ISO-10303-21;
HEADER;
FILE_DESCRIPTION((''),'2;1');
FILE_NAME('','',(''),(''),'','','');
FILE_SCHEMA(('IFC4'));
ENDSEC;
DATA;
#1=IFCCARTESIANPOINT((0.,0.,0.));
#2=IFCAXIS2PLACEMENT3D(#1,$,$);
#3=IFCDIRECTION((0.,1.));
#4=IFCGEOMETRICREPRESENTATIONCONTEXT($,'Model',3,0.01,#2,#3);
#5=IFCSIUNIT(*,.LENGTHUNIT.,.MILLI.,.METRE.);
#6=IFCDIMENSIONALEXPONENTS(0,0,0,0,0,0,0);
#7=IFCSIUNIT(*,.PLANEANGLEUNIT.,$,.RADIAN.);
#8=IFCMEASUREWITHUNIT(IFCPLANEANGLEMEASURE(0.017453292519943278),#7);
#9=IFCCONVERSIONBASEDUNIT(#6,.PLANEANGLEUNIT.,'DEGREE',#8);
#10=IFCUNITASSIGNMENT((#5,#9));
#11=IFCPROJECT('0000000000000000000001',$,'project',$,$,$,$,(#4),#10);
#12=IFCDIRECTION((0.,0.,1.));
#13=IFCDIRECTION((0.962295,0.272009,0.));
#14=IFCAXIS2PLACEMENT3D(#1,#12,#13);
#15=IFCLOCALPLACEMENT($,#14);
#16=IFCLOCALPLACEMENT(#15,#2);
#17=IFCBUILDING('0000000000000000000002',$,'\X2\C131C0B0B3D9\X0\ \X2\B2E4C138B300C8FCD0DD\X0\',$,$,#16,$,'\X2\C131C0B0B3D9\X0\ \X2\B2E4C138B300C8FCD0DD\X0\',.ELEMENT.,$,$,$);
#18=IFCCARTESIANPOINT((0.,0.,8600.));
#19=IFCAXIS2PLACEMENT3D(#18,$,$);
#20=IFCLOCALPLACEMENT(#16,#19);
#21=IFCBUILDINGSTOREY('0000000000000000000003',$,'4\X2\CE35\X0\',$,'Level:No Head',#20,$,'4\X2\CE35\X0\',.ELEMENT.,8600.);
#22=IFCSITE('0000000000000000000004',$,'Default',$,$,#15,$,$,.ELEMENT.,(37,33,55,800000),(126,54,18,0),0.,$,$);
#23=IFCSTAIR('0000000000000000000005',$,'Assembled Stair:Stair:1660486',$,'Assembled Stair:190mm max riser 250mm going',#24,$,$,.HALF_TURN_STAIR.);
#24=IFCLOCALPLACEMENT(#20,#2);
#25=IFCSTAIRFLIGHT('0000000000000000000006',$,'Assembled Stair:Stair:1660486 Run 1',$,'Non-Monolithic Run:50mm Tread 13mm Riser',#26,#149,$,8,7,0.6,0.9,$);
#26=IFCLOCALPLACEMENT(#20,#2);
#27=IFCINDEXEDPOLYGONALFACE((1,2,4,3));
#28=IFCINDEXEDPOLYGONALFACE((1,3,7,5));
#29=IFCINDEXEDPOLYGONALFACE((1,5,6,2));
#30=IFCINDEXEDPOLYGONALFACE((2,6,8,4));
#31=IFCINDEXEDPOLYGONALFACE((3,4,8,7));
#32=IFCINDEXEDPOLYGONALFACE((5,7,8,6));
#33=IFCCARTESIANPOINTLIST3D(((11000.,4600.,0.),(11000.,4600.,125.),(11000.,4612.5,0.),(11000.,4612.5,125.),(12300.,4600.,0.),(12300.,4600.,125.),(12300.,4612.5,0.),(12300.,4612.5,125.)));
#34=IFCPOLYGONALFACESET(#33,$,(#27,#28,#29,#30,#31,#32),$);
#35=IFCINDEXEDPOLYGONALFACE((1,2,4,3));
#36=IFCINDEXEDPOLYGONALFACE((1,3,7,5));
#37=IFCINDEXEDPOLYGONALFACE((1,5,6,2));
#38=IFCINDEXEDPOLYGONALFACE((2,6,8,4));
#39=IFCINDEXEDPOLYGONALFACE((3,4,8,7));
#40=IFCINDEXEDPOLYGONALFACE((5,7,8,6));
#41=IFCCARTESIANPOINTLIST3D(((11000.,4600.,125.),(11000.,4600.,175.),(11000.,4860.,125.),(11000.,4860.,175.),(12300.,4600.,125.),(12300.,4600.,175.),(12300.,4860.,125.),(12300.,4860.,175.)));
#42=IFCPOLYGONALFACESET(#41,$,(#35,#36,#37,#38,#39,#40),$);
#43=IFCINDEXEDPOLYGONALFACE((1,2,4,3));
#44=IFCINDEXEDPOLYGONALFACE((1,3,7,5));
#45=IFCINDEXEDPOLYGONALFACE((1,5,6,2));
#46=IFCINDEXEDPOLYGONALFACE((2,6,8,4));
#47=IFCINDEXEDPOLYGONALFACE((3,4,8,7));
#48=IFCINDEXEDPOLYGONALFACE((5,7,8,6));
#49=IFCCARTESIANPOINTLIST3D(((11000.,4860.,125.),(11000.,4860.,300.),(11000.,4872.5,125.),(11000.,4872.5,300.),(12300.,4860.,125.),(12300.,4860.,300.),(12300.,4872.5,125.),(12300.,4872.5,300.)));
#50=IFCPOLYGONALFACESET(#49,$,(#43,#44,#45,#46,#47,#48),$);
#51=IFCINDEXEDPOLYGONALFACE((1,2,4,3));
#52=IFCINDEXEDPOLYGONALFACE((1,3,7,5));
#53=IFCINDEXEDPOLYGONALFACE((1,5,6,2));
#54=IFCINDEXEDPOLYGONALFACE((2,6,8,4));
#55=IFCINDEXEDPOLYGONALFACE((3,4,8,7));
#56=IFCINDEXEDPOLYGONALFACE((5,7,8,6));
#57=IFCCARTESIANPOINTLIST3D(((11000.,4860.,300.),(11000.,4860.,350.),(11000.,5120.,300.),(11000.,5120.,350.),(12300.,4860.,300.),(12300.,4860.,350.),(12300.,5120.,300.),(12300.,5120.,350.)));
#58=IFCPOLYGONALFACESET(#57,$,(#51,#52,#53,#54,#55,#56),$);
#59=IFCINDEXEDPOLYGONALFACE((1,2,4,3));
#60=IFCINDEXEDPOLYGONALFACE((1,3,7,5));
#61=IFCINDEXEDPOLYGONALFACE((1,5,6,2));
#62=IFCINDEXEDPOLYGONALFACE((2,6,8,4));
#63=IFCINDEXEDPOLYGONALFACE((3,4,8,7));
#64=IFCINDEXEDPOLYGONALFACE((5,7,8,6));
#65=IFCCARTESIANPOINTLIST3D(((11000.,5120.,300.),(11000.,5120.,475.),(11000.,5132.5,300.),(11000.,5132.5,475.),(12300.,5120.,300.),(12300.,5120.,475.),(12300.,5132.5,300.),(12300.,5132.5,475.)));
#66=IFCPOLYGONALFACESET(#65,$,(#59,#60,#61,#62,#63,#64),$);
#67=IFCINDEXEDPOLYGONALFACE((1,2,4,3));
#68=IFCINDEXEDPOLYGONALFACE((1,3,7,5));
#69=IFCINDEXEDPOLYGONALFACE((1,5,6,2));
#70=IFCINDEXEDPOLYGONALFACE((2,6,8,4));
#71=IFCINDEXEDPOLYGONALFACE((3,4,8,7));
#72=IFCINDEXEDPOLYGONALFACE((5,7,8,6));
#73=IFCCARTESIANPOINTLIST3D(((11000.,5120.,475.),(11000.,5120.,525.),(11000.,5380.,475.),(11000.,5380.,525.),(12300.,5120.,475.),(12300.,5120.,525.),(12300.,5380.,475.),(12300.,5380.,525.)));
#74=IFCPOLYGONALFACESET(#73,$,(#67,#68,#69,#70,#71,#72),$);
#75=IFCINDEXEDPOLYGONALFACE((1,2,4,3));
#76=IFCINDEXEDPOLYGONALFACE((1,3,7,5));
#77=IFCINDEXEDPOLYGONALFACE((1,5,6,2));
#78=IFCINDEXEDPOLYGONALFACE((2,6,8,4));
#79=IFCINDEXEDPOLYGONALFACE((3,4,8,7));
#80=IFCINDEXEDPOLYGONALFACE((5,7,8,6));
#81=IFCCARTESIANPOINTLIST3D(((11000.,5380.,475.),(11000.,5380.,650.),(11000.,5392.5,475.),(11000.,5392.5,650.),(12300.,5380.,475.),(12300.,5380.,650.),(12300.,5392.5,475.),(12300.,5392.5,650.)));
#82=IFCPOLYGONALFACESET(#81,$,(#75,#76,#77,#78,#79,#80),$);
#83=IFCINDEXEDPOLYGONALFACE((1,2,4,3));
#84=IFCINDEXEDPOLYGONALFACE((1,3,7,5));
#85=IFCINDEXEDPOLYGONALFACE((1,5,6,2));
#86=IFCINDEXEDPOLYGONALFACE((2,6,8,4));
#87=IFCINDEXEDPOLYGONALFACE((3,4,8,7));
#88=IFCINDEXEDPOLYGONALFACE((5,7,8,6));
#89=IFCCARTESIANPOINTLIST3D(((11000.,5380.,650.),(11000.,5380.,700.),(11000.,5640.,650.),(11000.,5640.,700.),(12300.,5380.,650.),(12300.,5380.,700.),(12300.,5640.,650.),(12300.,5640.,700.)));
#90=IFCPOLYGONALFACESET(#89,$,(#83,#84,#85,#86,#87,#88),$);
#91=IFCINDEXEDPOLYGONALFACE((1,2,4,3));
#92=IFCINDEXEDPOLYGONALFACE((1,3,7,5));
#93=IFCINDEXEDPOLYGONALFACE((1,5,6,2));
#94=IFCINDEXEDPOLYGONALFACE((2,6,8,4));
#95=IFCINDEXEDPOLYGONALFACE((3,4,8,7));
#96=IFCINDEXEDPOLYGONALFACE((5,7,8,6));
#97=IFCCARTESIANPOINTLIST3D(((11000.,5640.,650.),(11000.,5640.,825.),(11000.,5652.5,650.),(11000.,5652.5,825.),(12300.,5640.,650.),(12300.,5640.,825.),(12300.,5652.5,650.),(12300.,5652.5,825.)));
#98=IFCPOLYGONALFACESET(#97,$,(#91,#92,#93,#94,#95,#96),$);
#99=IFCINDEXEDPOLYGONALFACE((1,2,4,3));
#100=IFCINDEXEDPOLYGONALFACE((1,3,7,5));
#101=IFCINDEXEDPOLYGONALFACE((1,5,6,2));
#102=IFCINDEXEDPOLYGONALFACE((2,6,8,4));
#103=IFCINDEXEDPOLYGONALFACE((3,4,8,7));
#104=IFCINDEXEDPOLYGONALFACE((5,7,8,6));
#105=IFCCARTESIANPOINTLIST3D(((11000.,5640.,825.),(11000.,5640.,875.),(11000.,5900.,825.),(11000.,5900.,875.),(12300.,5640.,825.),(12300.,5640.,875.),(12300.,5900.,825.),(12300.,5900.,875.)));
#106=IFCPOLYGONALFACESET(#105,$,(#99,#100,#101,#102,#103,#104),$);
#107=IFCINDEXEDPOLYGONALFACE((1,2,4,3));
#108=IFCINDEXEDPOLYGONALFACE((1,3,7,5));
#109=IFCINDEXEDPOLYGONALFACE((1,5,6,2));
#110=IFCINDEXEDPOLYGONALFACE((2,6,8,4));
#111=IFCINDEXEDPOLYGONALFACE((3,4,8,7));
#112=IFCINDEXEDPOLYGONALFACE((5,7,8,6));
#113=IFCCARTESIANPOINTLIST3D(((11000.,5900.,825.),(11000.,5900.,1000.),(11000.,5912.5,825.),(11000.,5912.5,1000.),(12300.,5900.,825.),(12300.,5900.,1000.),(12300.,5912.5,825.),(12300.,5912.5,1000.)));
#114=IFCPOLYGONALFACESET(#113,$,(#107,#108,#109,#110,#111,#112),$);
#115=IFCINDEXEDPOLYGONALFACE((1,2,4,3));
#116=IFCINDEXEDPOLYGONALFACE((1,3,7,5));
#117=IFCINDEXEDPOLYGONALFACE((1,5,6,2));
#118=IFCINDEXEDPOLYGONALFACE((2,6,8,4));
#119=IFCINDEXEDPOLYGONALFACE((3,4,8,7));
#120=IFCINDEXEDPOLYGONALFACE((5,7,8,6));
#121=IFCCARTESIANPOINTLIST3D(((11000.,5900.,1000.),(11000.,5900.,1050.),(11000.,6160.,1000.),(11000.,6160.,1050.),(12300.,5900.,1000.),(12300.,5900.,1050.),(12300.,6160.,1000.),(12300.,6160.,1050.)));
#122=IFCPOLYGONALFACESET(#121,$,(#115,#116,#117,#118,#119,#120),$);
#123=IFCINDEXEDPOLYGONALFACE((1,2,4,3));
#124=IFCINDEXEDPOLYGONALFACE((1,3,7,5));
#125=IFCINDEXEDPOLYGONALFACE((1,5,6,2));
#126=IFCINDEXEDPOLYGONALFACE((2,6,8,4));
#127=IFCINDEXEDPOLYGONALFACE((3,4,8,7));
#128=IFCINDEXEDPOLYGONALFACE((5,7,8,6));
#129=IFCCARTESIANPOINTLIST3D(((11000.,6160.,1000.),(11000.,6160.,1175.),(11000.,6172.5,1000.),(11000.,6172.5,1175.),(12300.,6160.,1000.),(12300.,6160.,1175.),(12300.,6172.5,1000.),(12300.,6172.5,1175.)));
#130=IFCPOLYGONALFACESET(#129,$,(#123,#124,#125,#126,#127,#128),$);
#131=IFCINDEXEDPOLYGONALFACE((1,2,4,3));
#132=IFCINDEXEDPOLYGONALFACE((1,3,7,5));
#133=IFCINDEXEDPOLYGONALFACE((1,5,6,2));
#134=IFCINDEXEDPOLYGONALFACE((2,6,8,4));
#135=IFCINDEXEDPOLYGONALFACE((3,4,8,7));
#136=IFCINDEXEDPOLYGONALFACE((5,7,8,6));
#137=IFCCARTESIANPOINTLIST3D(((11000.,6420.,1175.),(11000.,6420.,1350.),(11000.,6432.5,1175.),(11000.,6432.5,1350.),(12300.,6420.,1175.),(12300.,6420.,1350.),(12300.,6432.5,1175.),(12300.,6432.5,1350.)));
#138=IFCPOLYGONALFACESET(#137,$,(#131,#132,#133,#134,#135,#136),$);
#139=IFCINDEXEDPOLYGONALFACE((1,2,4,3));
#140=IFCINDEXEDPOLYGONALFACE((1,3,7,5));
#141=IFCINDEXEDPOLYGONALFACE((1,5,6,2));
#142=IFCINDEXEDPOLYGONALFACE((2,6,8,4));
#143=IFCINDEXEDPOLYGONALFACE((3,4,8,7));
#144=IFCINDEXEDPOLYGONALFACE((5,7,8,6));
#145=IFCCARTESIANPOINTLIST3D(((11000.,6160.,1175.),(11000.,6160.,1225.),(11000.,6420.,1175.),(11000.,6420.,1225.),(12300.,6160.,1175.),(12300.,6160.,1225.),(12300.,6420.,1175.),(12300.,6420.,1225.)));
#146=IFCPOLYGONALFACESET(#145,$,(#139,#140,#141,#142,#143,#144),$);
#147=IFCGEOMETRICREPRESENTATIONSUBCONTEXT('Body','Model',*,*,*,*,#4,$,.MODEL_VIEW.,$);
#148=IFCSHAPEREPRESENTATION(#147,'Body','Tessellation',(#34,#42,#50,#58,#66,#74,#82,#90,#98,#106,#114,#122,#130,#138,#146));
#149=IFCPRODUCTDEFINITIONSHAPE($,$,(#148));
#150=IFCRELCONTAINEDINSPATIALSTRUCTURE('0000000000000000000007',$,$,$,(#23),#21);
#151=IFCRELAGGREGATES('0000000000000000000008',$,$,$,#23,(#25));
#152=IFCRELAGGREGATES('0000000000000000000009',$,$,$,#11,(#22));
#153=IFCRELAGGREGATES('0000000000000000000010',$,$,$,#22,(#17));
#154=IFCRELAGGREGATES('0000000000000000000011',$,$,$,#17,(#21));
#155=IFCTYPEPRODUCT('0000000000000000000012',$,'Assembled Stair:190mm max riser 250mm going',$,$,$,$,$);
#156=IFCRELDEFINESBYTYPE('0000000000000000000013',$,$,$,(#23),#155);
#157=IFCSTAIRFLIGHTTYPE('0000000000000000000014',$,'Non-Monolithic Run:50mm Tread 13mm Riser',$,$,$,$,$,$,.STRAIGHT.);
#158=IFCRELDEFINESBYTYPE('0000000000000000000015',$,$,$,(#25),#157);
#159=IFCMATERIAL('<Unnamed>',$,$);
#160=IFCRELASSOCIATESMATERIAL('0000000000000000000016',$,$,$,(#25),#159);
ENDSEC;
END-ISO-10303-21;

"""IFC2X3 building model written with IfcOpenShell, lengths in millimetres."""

from ifc_helpers import new_model, entity, si_unit, converted_unit, direction, frame, frame_2d, origin, origin_2d_with_axis, place, context, subcontext, project, spatial, rectangle, extrude, material, type_object, element, aggregate, save


model = new_model("IFC2X3")

# Units and contexts
model_context = context("Model", 3, precision=0.01, world=origin(), true_north=direction((0.0, 1.0)))
body_context = subcontext(model_context, "Body", "Model", "MODEL_VIEW")
ifc_project = project(units=[si_unit("LENGTHUNIT", "METRE", prefix="MILLI"), converted_unit("PLANEANGLEUNIT", "DEGREE", entity("IfcPlaneAngleMeasure", 0.017453292519943278), si_unit("PLANEANGLEUNIT", "RADIAN"), dimensions=[0, 0, 0, 0, 0, 0, 0])], contexts=[model_context])

# Site, building, storey
site_placement = place(None, frame((0.0, 0.0, 0.0), z_axis=(0.0, 0.0, 1.0), x_axis=(0.962295, 0.272009, 0.0)))
site = spatial("IfcSite", under=ifc_project, at=site_placement, Name="Default", CompositionType="ELEMENT", RefLatitude=(37, 33, 55, 800000), RefLongitude=(126, 54, 18, 0), RefElevation=0.0)
building_placement = place(site_placement, origin())
building = spatial("IfcBuilding", under=site, at=building_placement, Name="성산동 다세대주택", LongName="성산동 다세대주택", CompositionType="ELEMENT")
storey_placement = place(building_placement, frame((0.0, 0.0, 8600.0)))
storey = spatial("IfcBuildingStorey", under=building, at=storey_placement, Name="4층", ObjectType="Level:No Head", LongName="4층", CompositionType="ELEMENT", Elevation=8600.0)

# Stair
type_product = type_object("IfcTypeProduct", Name="Assembled Stair:190mm max riser 250mm going")
stair_placement = place(storey_placement, origin())
stair = element("IfcStair", 1, at=stair_placement, inside=storey, type_object=type_product, Name="Assembled Stair:Stair:1660486", ObjectType="Assembled Stair:190mm max riser 250mm going", ShapeType="HALF_TURN_STAIR")
ifc_material_1 = material(Name="<Unnamed>")

# Stair flight
stair_flight_type = type_object("IfcStairFlightType", Name="Non-Monolithic Run:50mm Tread 13mm Riser", PredefinedType="STRAIGHT")
stair_flight_1_placement = place(stair_placement, origin())
stair_flight_1 = element("IfcStairFlight", 2, at=stair_flight_1_placement, type_object=stair_flight_type, material=ifc_material_1, Name="Assembled Stair:Stair:1660486 Run 1", ObjectType="Non-Monolithic Run:50mm Tread 13mm Riser", NumberOfRiser=8, NumberOfTreads=7, RiserHeight=0.6, TreadLength=0.9, context=body_context, shape_type="SweptSolid", body=[
    extrude(rectangle(XDim=1300.0, YDim=12.5, at=frame_2d((0.0, 0.0), x_axis=(1.0, 0.0))), frame((11650.0, 4606.2, 0.0), z_axis=(0.0, 0.0, 1.0), x_axis=(-1.0, 0.0, 0.0)), (0.0, 0.0, 1.0), 125.0),
    extrude(rectangle(XDim=260.0, YDim=1300.0, at=frame_2d((0.0, 0.0), x_axis=(1.0, 0.0))), frame((11650.0, 4730.0, 125.0), z_axis=(0.0, 0.0, 1.0), x_axis=(0.0, -1.0, 0.0)), (0.0, 0.0, 1.0), 50.0),
    extrude(rectangle(XDim=1300.0, YDim=12.5, at=frame_2d((0.0, 0.0), x_axis=(1.0, 0.0))), frame((11650.0, 4866.2, 125.0), z_axis=(0.0, 0.0, 1.0), x_axis=(-1.0, 0.0, 0.0)), (0.0, 0.0, 1.0), 175.0),
    extrude(rectangle(XDim=260.0, YDim=1300.0, at=frame_2d((0.0, 0.0), x_axis=(1.0, 0.0))), frame((11650.0, 4990.0, 300.0), z_axis=(0.0, 0.0, 1.0), x_axis=(0.0, -1.0, 0.0)), (0.0, 0.0, 1.0), 50.0),
    extrude(rectangle(XDim=1300.0, YDim=12.5, at=origin_2d_with_axis()), frame((11650.0, 5126.2, 300.0), z_axis=(0.0, 0.0, 1.0), x_axis=(-1.0, 0.0, 0.0)), (0.0, 0.0, 1.0), 175.0),
    extrude(rectangle(XDim=260.0, YDim=1300.0, at=frame_2d((0.0, 0.0), x_axis=(1.0, 0.0))), frame((11650.0, 5250.0, 475.0), z_axis=(0.0, 0.0, 1.0), x_axis=(0.0, -1.0, 0.0)), (0.0, 0.0, 1.0), 50.0),
    extrude(rectangle(XDim=1300.0, YDim=12.5, at=frame_2d((0.0, 0.0), x_axis=(1.0, 0.0))), frame((11650.0, 5386.2, 475.0), z_axis=(0.0, 0.0, 1.0), x_axis=(-1.0, 0.0, 0.0)), (0.0, 0.0, 1.0), 175.0),
    extrude(rectangle(XDim=260.0, YDim=1300.0, at=origin_2d_with_axis()), frame((11650.0, 5510.0, 650.0), z_axis=(0.0, 0.0, 1.0), x_axis=(0.0, -1.0, 0.0)), (0.0, 0.0, 1.0), 50.0),
    extrude(rectangle(XDim=1300.0, YDim=12.5, at=frame_2d((0.0, 0.0), x_axis=(1.0, 0.0))), frame((11650.0, 5646.2, 650.0), z_axis=(0.0, 0.0, 1.0), x_axis=(-1.0, 0.0, 0.0)), (0.0, 0.0, 1.0), 175.0),
    extrude(rectangle(XDim=260.0, YDim=1300.0, at=origin_2d_with_axis()), frame((11650.0, 5770.0, 825.0), z_axis=(0.0, 0.0, 1.0), x_axis=(0.0, -1.0, 0.0)), (0.0, 0.0, 1.0), 50.0),
    extrude(rectangle(XDim=1300.0, YDim=12.5, at=origin_2d_with_axis()), frame((11650.0, 5906.2, 825.0), z_axis=(0.0, 0.0, 1.0), x_axis=(-1.0, 0.0, 0.0)), (0.0, 0.0, 1.0), 175.0),
    extrude(rectangle(XDim=260.0, YDim=1300.0, at=origin_2d_with_axis()), frame((11650.0, 6030.0, 1000.0), z_axis=(0.0, 0.0, 1.0), x_axis=(0.0, -1.0, 0.0)), (0.0, 0.0, 1.0), 50.0),
    extrude(rectangle(XDim=1300.0, YDim=12.5, at=frame_2d((0.0, 0.0), x_axis=(1.0, 0.0))), frame((11650.0, 6166.2, 1000.0), z_axis=(0.0, 0.0, 1.0), x_axis=(-1.0, 0.0, 0.0)), (0.0, 0.0, 1.0), 175.0),
    extrude(rectangle(XDim=1300.0, YDim=12.5, at=frame_2d((0.0, 0.0), x_axis=(1.0, 0.0))), frame((11650.0, 6426.3, 1175.0), z_axis=(0.0, 0.0, 1.0), x_axis=(-1.0, 0.0, 0.0)), (0.0, 0.0, 1.0), 175.0),
    extrude(rectangle(XDim=260.0, YDim=1300.0, at=origin_2d_with_axis()), frame((11650.0, 6290.0, 1175.0), z_axis=(0.0, 0.0, 1.0), x_axis=(0.0, -1.0, 0.0)), (0.0, 0.0, 1.0), 50.0),
])
aggregate(stair, [stair_flight_1])

save(model, "model.ifc")
